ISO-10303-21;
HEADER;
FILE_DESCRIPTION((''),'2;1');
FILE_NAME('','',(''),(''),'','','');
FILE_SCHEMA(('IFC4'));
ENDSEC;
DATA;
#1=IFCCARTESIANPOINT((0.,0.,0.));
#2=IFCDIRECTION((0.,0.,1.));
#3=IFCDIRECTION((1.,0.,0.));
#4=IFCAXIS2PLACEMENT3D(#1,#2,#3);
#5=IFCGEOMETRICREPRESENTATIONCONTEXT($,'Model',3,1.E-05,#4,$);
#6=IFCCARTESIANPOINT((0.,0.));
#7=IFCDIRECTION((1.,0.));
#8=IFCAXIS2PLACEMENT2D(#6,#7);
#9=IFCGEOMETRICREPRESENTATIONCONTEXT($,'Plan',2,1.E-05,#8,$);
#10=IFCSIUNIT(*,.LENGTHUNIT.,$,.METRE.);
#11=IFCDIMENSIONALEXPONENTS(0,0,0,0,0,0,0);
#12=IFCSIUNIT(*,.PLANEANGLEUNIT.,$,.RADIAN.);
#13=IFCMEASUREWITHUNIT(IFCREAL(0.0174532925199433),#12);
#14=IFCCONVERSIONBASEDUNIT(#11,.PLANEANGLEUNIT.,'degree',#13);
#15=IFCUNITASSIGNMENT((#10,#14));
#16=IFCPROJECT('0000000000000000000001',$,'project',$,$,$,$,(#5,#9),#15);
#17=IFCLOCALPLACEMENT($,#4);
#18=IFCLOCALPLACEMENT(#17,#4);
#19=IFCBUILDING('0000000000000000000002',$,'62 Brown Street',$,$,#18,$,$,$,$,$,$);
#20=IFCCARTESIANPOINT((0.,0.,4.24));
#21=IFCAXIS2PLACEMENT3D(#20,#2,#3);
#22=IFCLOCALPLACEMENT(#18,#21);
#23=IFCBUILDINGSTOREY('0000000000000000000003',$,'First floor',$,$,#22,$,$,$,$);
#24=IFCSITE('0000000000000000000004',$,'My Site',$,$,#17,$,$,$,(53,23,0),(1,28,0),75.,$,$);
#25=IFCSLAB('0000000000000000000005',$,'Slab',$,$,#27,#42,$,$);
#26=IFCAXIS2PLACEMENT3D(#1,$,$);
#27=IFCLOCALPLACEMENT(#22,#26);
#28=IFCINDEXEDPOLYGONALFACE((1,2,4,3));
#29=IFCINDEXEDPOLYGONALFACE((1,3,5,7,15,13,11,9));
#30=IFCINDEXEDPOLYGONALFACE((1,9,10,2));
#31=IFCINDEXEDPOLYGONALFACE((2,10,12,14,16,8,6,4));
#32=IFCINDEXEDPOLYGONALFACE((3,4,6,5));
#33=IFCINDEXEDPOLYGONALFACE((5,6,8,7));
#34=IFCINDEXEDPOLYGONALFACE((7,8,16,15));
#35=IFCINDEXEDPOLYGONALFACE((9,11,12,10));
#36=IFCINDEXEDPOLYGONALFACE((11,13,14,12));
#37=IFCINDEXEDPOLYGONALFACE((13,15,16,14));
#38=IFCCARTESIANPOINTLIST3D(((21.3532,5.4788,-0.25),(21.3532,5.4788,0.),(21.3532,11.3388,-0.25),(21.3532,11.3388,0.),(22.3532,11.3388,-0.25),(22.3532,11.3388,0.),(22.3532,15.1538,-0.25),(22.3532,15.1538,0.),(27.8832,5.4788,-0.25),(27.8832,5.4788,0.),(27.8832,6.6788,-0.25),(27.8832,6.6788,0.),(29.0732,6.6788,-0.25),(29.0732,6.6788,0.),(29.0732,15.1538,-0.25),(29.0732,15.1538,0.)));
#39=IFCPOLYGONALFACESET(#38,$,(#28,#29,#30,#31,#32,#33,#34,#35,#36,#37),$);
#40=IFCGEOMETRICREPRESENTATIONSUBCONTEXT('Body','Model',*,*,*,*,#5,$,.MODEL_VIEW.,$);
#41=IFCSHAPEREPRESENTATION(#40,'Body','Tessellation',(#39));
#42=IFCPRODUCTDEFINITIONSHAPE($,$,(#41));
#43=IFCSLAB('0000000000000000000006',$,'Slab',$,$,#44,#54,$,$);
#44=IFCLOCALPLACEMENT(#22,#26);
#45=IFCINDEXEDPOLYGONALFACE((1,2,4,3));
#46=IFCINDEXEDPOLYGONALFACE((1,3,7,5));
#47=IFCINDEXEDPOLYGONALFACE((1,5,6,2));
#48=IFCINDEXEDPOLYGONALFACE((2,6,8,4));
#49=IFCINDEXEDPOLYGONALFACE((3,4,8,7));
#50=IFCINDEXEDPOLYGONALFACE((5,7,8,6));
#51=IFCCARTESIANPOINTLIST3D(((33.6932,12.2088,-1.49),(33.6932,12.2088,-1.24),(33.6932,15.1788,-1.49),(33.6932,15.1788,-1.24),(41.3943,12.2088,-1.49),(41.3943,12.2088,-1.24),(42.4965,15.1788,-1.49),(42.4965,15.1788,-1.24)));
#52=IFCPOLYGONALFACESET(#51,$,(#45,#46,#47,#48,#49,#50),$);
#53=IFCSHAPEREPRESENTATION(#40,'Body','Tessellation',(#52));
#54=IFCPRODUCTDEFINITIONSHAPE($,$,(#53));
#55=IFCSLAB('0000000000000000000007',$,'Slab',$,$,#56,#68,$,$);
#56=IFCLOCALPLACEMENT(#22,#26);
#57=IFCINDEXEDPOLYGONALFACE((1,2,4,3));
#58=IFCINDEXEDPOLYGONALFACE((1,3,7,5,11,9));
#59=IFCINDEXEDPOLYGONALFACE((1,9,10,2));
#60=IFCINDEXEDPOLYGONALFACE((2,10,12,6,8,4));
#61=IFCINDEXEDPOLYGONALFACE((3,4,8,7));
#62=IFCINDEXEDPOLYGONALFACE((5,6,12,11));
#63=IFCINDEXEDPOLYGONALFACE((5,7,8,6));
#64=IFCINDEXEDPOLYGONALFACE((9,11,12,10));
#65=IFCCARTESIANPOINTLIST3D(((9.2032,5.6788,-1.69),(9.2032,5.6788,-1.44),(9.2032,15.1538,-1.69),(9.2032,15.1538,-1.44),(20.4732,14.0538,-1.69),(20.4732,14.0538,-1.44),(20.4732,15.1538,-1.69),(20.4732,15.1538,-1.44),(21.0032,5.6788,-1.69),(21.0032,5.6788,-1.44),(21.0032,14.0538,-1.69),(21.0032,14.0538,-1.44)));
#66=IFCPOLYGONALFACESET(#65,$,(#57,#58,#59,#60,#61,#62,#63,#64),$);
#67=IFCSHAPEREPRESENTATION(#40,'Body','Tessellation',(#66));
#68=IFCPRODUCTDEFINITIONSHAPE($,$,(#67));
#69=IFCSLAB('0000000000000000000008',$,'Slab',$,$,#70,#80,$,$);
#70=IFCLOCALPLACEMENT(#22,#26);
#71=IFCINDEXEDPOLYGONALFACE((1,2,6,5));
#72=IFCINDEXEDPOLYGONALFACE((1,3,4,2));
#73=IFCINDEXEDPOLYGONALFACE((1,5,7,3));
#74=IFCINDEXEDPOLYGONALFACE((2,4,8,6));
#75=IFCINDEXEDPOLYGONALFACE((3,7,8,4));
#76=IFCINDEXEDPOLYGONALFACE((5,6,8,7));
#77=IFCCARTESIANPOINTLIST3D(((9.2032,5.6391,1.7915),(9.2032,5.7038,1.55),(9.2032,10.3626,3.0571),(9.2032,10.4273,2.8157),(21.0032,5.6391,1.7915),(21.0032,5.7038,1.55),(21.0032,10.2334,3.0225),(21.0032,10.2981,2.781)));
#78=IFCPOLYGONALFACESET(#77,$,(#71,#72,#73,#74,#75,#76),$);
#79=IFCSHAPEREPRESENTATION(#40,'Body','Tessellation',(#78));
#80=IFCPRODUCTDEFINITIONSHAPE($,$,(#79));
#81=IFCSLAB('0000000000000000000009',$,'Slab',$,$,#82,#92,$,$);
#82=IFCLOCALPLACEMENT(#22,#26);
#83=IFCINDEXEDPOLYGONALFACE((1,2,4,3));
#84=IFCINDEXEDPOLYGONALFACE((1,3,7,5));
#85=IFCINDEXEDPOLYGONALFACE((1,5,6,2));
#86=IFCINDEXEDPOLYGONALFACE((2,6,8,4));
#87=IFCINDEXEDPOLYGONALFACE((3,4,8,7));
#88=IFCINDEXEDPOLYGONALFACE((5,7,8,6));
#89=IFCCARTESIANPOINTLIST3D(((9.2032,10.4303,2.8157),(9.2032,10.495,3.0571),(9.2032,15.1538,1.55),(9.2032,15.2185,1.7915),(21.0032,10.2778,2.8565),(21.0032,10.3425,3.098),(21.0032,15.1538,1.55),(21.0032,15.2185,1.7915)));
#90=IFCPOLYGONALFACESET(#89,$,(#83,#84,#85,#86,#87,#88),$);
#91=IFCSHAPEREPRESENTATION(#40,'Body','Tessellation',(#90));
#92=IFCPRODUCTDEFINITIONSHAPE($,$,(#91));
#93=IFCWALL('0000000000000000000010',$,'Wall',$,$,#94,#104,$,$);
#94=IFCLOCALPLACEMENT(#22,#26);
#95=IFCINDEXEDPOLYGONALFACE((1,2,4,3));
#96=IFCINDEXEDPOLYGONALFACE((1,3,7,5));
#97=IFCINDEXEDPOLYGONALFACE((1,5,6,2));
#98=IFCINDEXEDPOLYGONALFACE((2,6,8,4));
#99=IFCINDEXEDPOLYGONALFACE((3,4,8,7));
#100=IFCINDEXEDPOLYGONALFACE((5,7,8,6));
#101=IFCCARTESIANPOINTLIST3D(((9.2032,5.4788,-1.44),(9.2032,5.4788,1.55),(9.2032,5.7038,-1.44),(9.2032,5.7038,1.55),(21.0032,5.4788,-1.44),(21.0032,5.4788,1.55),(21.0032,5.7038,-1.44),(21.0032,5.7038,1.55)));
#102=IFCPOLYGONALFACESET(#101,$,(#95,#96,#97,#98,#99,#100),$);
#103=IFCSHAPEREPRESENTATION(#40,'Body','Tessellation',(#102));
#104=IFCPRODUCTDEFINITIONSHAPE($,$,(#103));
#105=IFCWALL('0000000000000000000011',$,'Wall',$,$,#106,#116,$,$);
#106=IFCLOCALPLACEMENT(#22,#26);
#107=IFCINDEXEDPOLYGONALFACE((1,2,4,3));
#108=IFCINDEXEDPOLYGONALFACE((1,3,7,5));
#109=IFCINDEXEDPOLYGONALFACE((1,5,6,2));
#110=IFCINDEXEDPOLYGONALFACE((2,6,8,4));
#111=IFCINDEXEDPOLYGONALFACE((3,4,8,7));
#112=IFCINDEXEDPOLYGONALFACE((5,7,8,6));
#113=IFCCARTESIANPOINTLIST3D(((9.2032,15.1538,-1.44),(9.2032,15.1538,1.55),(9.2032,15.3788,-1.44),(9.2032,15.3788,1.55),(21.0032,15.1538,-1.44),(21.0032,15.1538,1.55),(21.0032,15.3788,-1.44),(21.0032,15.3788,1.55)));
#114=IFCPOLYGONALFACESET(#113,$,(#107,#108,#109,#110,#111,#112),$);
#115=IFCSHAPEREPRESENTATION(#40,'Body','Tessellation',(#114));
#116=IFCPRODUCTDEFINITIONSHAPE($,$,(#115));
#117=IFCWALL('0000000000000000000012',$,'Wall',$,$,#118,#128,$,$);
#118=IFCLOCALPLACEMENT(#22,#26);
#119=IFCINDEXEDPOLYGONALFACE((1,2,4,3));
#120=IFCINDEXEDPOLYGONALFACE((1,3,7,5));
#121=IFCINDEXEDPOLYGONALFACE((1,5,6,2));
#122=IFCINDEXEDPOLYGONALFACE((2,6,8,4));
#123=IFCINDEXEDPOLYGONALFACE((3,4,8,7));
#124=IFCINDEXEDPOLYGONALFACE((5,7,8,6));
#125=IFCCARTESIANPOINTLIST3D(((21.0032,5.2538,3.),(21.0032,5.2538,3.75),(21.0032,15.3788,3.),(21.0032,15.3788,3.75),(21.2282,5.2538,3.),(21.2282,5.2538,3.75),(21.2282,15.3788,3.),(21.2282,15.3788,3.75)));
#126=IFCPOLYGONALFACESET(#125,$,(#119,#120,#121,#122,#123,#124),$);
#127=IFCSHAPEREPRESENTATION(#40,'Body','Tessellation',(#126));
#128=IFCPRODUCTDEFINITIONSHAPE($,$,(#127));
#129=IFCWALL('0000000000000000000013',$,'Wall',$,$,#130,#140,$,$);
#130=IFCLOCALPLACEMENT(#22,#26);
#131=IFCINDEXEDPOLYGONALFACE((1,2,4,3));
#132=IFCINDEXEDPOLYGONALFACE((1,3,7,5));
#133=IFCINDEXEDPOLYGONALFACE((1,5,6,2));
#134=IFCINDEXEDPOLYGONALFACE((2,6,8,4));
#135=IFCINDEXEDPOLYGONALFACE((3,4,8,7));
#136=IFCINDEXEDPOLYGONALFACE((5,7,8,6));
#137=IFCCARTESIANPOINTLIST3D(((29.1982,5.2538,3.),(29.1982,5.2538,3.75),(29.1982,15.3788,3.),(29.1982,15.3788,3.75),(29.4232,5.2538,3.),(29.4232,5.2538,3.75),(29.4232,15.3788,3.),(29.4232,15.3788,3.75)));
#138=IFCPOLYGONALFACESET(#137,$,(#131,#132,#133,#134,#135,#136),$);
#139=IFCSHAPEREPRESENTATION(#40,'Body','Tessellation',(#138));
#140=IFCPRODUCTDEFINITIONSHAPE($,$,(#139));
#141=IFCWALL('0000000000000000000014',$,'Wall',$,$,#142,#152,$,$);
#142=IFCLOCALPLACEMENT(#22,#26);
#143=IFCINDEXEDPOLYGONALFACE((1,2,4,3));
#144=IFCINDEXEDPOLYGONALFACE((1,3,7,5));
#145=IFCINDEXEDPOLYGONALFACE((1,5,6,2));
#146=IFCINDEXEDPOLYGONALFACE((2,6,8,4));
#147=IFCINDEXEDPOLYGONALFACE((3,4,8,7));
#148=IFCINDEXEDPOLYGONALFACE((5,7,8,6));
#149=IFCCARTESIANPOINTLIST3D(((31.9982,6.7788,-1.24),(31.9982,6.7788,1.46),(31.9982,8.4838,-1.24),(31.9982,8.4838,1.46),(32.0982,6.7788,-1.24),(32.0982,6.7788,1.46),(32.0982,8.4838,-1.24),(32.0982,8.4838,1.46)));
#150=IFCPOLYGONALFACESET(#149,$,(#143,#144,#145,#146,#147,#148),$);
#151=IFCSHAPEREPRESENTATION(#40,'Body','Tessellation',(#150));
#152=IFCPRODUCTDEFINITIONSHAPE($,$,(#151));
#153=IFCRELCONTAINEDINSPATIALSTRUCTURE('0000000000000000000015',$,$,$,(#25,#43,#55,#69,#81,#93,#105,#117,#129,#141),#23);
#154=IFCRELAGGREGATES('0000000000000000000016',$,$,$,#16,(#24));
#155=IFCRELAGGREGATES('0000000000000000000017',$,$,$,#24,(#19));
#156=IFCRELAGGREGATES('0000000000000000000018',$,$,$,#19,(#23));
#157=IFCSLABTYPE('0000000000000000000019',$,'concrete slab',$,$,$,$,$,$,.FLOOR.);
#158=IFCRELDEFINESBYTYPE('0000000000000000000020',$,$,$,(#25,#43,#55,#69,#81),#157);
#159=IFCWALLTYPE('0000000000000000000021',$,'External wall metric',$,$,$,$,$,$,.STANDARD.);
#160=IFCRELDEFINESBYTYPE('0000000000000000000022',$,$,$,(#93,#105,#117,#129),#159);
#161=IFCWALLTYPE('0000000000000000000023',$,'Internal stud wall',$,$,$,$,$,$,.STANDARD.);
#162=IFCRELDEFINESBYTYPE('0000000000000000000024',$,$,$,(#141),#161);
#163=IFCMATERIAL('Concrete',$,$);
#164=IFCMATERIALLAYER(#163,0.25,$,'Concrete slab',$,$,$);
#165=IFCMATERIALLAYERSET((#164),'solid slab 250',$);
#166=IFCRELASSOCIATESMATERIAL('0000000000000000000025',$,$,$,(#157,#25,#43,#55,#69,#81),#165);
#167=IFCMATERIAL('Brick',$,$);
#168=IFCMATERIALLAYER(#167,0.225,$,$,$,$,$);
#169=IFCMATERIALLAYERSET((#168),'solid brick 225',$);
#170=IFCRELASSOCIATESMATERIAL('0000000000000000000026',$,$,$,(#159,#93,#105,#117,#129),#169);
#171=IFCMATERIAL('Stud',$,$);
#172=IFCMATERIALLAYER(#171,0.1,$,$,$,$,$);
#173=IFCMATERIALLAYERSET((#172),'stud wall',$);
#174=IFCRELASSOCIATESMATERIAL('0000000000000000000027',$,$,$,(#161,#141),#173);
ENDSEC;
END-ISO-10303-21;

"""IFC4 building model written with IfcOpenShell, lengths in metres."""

from ifc_helpers import new_model, entity, si_unit, converted_unit, frame, origin_with_axes, origin_2d_with_axis, place, context, subcontext, project, spatial, line, indexed_curve, outline, extrude, material, layer, layer_set, layer_usage, type_object, element, save


model = new_model("IFC4")

# Units and contexts
model_context = context("Model", 3, precision=1e-05, world=origin_with_axes())
plan_context = context("Plan", 2, precision=1e-05, world=origin_2d_with_axis())
body_context_1 = subcontext(model_context, "Body", "Model", "MODEL_VIEW")
ifc_project = project(units=[si_unit("LENGTHUNIT", "METRE"), converted_unit("PLANEANGLEUNIT", "degree", entity("IfcReal", 0.0174532925199433), si_unit("PLANEANGLEUNIT", "RADIAN"), dimensions=[0, 0, 0, 0, 0, 0, 0])], contexts=[model_context, plan_context])

# Site, building, storey
site_placement = place(None, origin_with_axes())
site = spatial("IfcSite", under=ifc_project, at=site_placement, Name="My Site", RefLatitude=(53, 23, 0), RefLongitude=(1, 28, 0), RefElevation=75.0)
building_placement = place(site_placement, origin_with_axes())
building = spatial("IfcBuilding", under=site, at=building_placement, Name="62 Brown Street")
storey_placement = place(building_placement, frame((0.0, 0.0, 4.24), z_axis=(0.0, 0.0, 1.0), x_axis=(1.0, 0.0, 0.0)))
storey = spatial("IfcBuildingStorey", under=building, at=storey_placement, Name="First floor")

# Shared definitions
ifc_material_1 = material(Name="Concrete")

# Slabs
ifc_layer_1 = layer(ifc_material_1, 0.25, Name="Concrete slab")
ifc_layer_set_1 = layer_set([ifc_layer_1], Name="solid slab 250")
ifc_layer_usage_1 = layer_usage(ifc_layer_set_1, "AXIS3", "POSITIVE", 0.0)
slab_type = type_object("IfcSlabType", Name="concrete slab", PredefinedType="FLOOR", material=ifc_layer_set_1)
slab_1_placement = place(storey_placement, frame((21.3532, 5.4788, -0.25), z_axis=(0.0, 0.0, 1.0), x_axis=(1.0, 0.0, 0.0)))
element("IfcSlab", 1, at=slab_1_placement, inside=storey, type_object=slab_type, material=ifc_layer_usage_1, Name="Slab", context=body_context_1, shape_type="SweptSolid", body=[
    extrude(outline(indexed_curve([(6.53, 1.2), (7.72, 1.2), (7.72, 9.675), (1.0, 9.675), (1.0, 5.86), (0.0, 5.86), (0.0, 0.0), (6.53, 0.0), (6.53, 1.2)])), None, (0.0, 0.0, 1.0), 0.25),
])
ifc_layer_usage_2 = layer_usage(ifc_layer_set_1, "AXIS3", "POSITIVE", 0.0)
slab_2_placement = place(storey_placement, frame((33.6932, 12.2088, -1.49), z_axis=(0.0, 0.0, 1.0), x_axis=(1.0, 0.0, 0.0)))
element("IfcSlab", 2, at=slab_2_placement, inside=storey, type_object=slab_type, material=ifc_layer_usage_2, Name="Slab", context=body_context_1, shape_type="SweptSolid", body=[
    extrude(outline(indexed_curve([(8.8033, 2.97), (7.7011, 0.0), (0.0, 0.0), (0.0, 2.97)], segments=[line(4, 1), line(1, 2), line(2, 3), line(3, 4)], self_intersect=False)), None, (0.0, 0.0, 1.0), 0.25),
])
ifc_layer_usage_3 = layer_usage(ifc_layer_set_1, "AXIS3", "POSITIVE", 0.0)
slab_3_placement = place(storey_placement, frame((9.2032, 5.6788, -1.69), z_axis=(0.0, 0.0, 1.0), x_axis=(1.0, 0.0, 0.0)))
element("IfcSlab", 3, at=slab_3_placement, inside=storey, type_object=slab_type, material=ifc_layer_usage_3, Name="Slab", context=body_context_1, shape_type="SweptSolid", body=[
    extrude(outline(indexed_curve([(11.27, 9.475), (11.8, 0.0), (0.0, 0.0), (0.0, 9.475), (11.8, 8.375), (11.27, 8.375)], segments=[line(6, 1), line(1, 4), line(4, 3), line(3, 2), line(2, 5), line(5, 6)], self_intersect=False)), None, (0.0, 0.0, 1.0), 0.25),
])
ifc_layer_usage_4 = layer_usage(ifc_layer_set_1, "AXIS3", "POSITIVE", 0.0)
slab_4_placement = place(storey_placement, frame((9.2032, 5.7038, 1.55), z_axis=(0.0, -0.258819, 0.965926), x_axis=(1.0, 0.0, 0.0)))
element("IfcSlab", 4, at=slab_4_placement, inside=storey, type_object=slab_type, material=ifc_layer_usage_4, Name="Slab", context=body_context_1, shape_type="SweptSolid", body=[
    extrude(outline(indexed_curve([(0.0, 4.8901), (0.0, 0.0), (11.8, 0.0), (11.8, 4.7563)], segments=[line(3, 2), line(2, 1), line(1, 4), line(4, 3)], self_intersect=False)), None, (0.0, 0.0, 1.0), 0.25),
])
ifc_layer_usage_5 = layer_usage(ifc_layer_set_1, "AXIS3", "POSITIVE", 0.0)
slab_5_placement = place(storey_placement, frame((21.0032, 15.1538, 1.55), z_axis=(0.0, 0.258819, 0.965926), x_axis=(-1.0, 0.0, 0.0)))
element("IfcSlab", 5, at=slab_5_placement, inside=storey, type_object=slab_type, material=ifc_layer_usage_5, Name="Slab", context=body_context_1, shape_type="SweptSolid", body=[
    extrude(outline(indexed_curve([(0.0, 0.0), (11.8, 0.0), (11.8, 4.8901), (0.0, 5.048)], segments=[line(4, 1), line(1, 2), line(2, 3), line(3, 4)], self_intersect=False)), None, (0.0, 0.0, 1.0), 0.25),
])

# Walls
ifc_material_2 = material(Name="Brick")
ifc_layer_2 = layer(ifc_material_2, 0.225)
ifc_layer_set_2 = layer_set([ifc_layer_2], Name="solid brick 225")
ifc_layer_usage_6 = layer_usage(ifc_layer_set_2, "AXIS2", "POSITIVE", 0.0)
wall_type_1 = type_object("IfcWallType", Name="External wall metric", PredefinedType="STANDARD", material=ifc_layer_set_2)
wall_1_placement = place(storey_placement, frame((9.2032, 5.4788, -1.44), z_axis=(0.0, 0.0, 1.0), x_axis=(1.0, 0.0, 0.0)))
element("IfcWall", 6, at=wall_1_placement, inside=storey, type_object=wall_type_1, material=ifc_layer_usage_6, Name="Wall", context=body_context_1, shape_type="SweptSolid", body=[
    extrude(outline(indexed_curve([(0.0, 0.0), (0.0, 0.225), (11.8, 0.225), (11.8, 0.0), (0.0, 0.0)], self_intersect=False)), origin_with_axes(), (0.0, 0.0, 1.0), 2.99),
])
ifc_layer_usage_7 = layer_usage(ifc_layer_set_2, "AXIS2", "POSITIVE", 0.0)
wall_2_placement = place(storey_placement, frame((21.0032, 15.3788, -1.44), z_axis=(0.0, 0.0, 1.0), x_axis=(-1.0, 0.0, 0.0)))
element("IfcWall", 7, at=wall_2_placement, inside=storey, type_object=wall_type_1, material=ifc_layer_usage_7, Name="Wall", context=body_context_1, shape_type="SweptSolid", body=[
    extrude(outline(indexed_curve([(0.0, 0.0), (0.0, 0.225), (11.8, 0.225), (11.8, 0.0), (0.0, 0.0)], self_intersect=False)), origin_with_axes(), (0.0, 0.0, 1.0), 2.99),
])
ifc_layer_usage_8 = layer_usage(ifc_layer_set_2, "AXIS2", "POSITIVE", 0.0)
wall_3_placement = place(storey_placement, frame((21.0032, 15.3788, 3.0), z_axis=(0.0, 0.0, 1.0), x_axis=(0.0, -1.0, 0.0)))
element("IfcWall", 8, at=wall_3_placement, inside=storey, type_object=wall_type_1, material=ifc_layer_usage_8, Name="Wall", context=body_context_1, shape_type="SweptSolid", body=[
    extrude(outline(indexed_curve([(0.0, 0.0), (0.0, 0.225), (10.125, 0.225), (10.125, 0.0), (0.0, 0.0)], self_intersect=False)), origin_with_axes(), (0.0, 0.0, 1.0), 0.75),
])
ifc_layer_usage_9 = layer_usage(ifc_layer_set_2, "AXIS2", "POSITIVE", 0.0)
wall_4_placement = place(storey_placement, frame((29.4232, 5.2538, 3.0), z_axis=(0.0, 0.0, 1.0), x_axis=(0.0, 1.0, 0.0)))
element("IfcWall", 9, at=wall_4_placement, inside=storey, type_object=wall_type_1, material=ifc_layer_usage_9, Name="Wall", context=body_context_1, shape_type="SweptSolid", body=[
    extrude(outline(indexed_curve([(0.0, 0.0), (0.0, 0.225), (10.125, 0.225), (10.125, 0.0), (0.0, 0.0)], self_intersect=False)), origin_with_axes(), (0.0, 0.0, 1.0), 0.75),
])
ifc_material_3 = material(Name="Stud")
ifc_layer_3 = layer(ifc_material_3, 0.1)
ifc_layer_set_3 = layer_set([ifc_layer_3], Name="stud wall")
ifc_layer_usage_10 = layer_usage(ifc_layer_set_3, "AXIS2", "POSITIVE", 0.0)
wall_type_2 = type_object("IfcWallType", Name="Internal stud wall", PredefinedType="STANDARD", material=ifc_layer_set_3)
wall_5_placement = place(storey_placement, frame((32.0982, 6.7788, -1.24), z_axis=(0.0, 0.0, 1.0), x_axis=(0.000001, 1.0, 0.0)))
element("IfcWall", 10, at=wall_5_placement, inside=storey, type_object=wall_type_2, material=ifc_layer_usage_10, Name="Wall", context=body_context_1, shape_type="SweptSolid", body=[
    extrude(outline(indexed_curve([(0.0, 0.0), (0.0, 0.1), (1.705, 0.1), (1.705, 0.0), (0.0, 0.0)], self_intersect=False)), origin_with_axes(), (0.0, 0.0, 1.0), 2.7),
])

save(model, "model.ifc")
